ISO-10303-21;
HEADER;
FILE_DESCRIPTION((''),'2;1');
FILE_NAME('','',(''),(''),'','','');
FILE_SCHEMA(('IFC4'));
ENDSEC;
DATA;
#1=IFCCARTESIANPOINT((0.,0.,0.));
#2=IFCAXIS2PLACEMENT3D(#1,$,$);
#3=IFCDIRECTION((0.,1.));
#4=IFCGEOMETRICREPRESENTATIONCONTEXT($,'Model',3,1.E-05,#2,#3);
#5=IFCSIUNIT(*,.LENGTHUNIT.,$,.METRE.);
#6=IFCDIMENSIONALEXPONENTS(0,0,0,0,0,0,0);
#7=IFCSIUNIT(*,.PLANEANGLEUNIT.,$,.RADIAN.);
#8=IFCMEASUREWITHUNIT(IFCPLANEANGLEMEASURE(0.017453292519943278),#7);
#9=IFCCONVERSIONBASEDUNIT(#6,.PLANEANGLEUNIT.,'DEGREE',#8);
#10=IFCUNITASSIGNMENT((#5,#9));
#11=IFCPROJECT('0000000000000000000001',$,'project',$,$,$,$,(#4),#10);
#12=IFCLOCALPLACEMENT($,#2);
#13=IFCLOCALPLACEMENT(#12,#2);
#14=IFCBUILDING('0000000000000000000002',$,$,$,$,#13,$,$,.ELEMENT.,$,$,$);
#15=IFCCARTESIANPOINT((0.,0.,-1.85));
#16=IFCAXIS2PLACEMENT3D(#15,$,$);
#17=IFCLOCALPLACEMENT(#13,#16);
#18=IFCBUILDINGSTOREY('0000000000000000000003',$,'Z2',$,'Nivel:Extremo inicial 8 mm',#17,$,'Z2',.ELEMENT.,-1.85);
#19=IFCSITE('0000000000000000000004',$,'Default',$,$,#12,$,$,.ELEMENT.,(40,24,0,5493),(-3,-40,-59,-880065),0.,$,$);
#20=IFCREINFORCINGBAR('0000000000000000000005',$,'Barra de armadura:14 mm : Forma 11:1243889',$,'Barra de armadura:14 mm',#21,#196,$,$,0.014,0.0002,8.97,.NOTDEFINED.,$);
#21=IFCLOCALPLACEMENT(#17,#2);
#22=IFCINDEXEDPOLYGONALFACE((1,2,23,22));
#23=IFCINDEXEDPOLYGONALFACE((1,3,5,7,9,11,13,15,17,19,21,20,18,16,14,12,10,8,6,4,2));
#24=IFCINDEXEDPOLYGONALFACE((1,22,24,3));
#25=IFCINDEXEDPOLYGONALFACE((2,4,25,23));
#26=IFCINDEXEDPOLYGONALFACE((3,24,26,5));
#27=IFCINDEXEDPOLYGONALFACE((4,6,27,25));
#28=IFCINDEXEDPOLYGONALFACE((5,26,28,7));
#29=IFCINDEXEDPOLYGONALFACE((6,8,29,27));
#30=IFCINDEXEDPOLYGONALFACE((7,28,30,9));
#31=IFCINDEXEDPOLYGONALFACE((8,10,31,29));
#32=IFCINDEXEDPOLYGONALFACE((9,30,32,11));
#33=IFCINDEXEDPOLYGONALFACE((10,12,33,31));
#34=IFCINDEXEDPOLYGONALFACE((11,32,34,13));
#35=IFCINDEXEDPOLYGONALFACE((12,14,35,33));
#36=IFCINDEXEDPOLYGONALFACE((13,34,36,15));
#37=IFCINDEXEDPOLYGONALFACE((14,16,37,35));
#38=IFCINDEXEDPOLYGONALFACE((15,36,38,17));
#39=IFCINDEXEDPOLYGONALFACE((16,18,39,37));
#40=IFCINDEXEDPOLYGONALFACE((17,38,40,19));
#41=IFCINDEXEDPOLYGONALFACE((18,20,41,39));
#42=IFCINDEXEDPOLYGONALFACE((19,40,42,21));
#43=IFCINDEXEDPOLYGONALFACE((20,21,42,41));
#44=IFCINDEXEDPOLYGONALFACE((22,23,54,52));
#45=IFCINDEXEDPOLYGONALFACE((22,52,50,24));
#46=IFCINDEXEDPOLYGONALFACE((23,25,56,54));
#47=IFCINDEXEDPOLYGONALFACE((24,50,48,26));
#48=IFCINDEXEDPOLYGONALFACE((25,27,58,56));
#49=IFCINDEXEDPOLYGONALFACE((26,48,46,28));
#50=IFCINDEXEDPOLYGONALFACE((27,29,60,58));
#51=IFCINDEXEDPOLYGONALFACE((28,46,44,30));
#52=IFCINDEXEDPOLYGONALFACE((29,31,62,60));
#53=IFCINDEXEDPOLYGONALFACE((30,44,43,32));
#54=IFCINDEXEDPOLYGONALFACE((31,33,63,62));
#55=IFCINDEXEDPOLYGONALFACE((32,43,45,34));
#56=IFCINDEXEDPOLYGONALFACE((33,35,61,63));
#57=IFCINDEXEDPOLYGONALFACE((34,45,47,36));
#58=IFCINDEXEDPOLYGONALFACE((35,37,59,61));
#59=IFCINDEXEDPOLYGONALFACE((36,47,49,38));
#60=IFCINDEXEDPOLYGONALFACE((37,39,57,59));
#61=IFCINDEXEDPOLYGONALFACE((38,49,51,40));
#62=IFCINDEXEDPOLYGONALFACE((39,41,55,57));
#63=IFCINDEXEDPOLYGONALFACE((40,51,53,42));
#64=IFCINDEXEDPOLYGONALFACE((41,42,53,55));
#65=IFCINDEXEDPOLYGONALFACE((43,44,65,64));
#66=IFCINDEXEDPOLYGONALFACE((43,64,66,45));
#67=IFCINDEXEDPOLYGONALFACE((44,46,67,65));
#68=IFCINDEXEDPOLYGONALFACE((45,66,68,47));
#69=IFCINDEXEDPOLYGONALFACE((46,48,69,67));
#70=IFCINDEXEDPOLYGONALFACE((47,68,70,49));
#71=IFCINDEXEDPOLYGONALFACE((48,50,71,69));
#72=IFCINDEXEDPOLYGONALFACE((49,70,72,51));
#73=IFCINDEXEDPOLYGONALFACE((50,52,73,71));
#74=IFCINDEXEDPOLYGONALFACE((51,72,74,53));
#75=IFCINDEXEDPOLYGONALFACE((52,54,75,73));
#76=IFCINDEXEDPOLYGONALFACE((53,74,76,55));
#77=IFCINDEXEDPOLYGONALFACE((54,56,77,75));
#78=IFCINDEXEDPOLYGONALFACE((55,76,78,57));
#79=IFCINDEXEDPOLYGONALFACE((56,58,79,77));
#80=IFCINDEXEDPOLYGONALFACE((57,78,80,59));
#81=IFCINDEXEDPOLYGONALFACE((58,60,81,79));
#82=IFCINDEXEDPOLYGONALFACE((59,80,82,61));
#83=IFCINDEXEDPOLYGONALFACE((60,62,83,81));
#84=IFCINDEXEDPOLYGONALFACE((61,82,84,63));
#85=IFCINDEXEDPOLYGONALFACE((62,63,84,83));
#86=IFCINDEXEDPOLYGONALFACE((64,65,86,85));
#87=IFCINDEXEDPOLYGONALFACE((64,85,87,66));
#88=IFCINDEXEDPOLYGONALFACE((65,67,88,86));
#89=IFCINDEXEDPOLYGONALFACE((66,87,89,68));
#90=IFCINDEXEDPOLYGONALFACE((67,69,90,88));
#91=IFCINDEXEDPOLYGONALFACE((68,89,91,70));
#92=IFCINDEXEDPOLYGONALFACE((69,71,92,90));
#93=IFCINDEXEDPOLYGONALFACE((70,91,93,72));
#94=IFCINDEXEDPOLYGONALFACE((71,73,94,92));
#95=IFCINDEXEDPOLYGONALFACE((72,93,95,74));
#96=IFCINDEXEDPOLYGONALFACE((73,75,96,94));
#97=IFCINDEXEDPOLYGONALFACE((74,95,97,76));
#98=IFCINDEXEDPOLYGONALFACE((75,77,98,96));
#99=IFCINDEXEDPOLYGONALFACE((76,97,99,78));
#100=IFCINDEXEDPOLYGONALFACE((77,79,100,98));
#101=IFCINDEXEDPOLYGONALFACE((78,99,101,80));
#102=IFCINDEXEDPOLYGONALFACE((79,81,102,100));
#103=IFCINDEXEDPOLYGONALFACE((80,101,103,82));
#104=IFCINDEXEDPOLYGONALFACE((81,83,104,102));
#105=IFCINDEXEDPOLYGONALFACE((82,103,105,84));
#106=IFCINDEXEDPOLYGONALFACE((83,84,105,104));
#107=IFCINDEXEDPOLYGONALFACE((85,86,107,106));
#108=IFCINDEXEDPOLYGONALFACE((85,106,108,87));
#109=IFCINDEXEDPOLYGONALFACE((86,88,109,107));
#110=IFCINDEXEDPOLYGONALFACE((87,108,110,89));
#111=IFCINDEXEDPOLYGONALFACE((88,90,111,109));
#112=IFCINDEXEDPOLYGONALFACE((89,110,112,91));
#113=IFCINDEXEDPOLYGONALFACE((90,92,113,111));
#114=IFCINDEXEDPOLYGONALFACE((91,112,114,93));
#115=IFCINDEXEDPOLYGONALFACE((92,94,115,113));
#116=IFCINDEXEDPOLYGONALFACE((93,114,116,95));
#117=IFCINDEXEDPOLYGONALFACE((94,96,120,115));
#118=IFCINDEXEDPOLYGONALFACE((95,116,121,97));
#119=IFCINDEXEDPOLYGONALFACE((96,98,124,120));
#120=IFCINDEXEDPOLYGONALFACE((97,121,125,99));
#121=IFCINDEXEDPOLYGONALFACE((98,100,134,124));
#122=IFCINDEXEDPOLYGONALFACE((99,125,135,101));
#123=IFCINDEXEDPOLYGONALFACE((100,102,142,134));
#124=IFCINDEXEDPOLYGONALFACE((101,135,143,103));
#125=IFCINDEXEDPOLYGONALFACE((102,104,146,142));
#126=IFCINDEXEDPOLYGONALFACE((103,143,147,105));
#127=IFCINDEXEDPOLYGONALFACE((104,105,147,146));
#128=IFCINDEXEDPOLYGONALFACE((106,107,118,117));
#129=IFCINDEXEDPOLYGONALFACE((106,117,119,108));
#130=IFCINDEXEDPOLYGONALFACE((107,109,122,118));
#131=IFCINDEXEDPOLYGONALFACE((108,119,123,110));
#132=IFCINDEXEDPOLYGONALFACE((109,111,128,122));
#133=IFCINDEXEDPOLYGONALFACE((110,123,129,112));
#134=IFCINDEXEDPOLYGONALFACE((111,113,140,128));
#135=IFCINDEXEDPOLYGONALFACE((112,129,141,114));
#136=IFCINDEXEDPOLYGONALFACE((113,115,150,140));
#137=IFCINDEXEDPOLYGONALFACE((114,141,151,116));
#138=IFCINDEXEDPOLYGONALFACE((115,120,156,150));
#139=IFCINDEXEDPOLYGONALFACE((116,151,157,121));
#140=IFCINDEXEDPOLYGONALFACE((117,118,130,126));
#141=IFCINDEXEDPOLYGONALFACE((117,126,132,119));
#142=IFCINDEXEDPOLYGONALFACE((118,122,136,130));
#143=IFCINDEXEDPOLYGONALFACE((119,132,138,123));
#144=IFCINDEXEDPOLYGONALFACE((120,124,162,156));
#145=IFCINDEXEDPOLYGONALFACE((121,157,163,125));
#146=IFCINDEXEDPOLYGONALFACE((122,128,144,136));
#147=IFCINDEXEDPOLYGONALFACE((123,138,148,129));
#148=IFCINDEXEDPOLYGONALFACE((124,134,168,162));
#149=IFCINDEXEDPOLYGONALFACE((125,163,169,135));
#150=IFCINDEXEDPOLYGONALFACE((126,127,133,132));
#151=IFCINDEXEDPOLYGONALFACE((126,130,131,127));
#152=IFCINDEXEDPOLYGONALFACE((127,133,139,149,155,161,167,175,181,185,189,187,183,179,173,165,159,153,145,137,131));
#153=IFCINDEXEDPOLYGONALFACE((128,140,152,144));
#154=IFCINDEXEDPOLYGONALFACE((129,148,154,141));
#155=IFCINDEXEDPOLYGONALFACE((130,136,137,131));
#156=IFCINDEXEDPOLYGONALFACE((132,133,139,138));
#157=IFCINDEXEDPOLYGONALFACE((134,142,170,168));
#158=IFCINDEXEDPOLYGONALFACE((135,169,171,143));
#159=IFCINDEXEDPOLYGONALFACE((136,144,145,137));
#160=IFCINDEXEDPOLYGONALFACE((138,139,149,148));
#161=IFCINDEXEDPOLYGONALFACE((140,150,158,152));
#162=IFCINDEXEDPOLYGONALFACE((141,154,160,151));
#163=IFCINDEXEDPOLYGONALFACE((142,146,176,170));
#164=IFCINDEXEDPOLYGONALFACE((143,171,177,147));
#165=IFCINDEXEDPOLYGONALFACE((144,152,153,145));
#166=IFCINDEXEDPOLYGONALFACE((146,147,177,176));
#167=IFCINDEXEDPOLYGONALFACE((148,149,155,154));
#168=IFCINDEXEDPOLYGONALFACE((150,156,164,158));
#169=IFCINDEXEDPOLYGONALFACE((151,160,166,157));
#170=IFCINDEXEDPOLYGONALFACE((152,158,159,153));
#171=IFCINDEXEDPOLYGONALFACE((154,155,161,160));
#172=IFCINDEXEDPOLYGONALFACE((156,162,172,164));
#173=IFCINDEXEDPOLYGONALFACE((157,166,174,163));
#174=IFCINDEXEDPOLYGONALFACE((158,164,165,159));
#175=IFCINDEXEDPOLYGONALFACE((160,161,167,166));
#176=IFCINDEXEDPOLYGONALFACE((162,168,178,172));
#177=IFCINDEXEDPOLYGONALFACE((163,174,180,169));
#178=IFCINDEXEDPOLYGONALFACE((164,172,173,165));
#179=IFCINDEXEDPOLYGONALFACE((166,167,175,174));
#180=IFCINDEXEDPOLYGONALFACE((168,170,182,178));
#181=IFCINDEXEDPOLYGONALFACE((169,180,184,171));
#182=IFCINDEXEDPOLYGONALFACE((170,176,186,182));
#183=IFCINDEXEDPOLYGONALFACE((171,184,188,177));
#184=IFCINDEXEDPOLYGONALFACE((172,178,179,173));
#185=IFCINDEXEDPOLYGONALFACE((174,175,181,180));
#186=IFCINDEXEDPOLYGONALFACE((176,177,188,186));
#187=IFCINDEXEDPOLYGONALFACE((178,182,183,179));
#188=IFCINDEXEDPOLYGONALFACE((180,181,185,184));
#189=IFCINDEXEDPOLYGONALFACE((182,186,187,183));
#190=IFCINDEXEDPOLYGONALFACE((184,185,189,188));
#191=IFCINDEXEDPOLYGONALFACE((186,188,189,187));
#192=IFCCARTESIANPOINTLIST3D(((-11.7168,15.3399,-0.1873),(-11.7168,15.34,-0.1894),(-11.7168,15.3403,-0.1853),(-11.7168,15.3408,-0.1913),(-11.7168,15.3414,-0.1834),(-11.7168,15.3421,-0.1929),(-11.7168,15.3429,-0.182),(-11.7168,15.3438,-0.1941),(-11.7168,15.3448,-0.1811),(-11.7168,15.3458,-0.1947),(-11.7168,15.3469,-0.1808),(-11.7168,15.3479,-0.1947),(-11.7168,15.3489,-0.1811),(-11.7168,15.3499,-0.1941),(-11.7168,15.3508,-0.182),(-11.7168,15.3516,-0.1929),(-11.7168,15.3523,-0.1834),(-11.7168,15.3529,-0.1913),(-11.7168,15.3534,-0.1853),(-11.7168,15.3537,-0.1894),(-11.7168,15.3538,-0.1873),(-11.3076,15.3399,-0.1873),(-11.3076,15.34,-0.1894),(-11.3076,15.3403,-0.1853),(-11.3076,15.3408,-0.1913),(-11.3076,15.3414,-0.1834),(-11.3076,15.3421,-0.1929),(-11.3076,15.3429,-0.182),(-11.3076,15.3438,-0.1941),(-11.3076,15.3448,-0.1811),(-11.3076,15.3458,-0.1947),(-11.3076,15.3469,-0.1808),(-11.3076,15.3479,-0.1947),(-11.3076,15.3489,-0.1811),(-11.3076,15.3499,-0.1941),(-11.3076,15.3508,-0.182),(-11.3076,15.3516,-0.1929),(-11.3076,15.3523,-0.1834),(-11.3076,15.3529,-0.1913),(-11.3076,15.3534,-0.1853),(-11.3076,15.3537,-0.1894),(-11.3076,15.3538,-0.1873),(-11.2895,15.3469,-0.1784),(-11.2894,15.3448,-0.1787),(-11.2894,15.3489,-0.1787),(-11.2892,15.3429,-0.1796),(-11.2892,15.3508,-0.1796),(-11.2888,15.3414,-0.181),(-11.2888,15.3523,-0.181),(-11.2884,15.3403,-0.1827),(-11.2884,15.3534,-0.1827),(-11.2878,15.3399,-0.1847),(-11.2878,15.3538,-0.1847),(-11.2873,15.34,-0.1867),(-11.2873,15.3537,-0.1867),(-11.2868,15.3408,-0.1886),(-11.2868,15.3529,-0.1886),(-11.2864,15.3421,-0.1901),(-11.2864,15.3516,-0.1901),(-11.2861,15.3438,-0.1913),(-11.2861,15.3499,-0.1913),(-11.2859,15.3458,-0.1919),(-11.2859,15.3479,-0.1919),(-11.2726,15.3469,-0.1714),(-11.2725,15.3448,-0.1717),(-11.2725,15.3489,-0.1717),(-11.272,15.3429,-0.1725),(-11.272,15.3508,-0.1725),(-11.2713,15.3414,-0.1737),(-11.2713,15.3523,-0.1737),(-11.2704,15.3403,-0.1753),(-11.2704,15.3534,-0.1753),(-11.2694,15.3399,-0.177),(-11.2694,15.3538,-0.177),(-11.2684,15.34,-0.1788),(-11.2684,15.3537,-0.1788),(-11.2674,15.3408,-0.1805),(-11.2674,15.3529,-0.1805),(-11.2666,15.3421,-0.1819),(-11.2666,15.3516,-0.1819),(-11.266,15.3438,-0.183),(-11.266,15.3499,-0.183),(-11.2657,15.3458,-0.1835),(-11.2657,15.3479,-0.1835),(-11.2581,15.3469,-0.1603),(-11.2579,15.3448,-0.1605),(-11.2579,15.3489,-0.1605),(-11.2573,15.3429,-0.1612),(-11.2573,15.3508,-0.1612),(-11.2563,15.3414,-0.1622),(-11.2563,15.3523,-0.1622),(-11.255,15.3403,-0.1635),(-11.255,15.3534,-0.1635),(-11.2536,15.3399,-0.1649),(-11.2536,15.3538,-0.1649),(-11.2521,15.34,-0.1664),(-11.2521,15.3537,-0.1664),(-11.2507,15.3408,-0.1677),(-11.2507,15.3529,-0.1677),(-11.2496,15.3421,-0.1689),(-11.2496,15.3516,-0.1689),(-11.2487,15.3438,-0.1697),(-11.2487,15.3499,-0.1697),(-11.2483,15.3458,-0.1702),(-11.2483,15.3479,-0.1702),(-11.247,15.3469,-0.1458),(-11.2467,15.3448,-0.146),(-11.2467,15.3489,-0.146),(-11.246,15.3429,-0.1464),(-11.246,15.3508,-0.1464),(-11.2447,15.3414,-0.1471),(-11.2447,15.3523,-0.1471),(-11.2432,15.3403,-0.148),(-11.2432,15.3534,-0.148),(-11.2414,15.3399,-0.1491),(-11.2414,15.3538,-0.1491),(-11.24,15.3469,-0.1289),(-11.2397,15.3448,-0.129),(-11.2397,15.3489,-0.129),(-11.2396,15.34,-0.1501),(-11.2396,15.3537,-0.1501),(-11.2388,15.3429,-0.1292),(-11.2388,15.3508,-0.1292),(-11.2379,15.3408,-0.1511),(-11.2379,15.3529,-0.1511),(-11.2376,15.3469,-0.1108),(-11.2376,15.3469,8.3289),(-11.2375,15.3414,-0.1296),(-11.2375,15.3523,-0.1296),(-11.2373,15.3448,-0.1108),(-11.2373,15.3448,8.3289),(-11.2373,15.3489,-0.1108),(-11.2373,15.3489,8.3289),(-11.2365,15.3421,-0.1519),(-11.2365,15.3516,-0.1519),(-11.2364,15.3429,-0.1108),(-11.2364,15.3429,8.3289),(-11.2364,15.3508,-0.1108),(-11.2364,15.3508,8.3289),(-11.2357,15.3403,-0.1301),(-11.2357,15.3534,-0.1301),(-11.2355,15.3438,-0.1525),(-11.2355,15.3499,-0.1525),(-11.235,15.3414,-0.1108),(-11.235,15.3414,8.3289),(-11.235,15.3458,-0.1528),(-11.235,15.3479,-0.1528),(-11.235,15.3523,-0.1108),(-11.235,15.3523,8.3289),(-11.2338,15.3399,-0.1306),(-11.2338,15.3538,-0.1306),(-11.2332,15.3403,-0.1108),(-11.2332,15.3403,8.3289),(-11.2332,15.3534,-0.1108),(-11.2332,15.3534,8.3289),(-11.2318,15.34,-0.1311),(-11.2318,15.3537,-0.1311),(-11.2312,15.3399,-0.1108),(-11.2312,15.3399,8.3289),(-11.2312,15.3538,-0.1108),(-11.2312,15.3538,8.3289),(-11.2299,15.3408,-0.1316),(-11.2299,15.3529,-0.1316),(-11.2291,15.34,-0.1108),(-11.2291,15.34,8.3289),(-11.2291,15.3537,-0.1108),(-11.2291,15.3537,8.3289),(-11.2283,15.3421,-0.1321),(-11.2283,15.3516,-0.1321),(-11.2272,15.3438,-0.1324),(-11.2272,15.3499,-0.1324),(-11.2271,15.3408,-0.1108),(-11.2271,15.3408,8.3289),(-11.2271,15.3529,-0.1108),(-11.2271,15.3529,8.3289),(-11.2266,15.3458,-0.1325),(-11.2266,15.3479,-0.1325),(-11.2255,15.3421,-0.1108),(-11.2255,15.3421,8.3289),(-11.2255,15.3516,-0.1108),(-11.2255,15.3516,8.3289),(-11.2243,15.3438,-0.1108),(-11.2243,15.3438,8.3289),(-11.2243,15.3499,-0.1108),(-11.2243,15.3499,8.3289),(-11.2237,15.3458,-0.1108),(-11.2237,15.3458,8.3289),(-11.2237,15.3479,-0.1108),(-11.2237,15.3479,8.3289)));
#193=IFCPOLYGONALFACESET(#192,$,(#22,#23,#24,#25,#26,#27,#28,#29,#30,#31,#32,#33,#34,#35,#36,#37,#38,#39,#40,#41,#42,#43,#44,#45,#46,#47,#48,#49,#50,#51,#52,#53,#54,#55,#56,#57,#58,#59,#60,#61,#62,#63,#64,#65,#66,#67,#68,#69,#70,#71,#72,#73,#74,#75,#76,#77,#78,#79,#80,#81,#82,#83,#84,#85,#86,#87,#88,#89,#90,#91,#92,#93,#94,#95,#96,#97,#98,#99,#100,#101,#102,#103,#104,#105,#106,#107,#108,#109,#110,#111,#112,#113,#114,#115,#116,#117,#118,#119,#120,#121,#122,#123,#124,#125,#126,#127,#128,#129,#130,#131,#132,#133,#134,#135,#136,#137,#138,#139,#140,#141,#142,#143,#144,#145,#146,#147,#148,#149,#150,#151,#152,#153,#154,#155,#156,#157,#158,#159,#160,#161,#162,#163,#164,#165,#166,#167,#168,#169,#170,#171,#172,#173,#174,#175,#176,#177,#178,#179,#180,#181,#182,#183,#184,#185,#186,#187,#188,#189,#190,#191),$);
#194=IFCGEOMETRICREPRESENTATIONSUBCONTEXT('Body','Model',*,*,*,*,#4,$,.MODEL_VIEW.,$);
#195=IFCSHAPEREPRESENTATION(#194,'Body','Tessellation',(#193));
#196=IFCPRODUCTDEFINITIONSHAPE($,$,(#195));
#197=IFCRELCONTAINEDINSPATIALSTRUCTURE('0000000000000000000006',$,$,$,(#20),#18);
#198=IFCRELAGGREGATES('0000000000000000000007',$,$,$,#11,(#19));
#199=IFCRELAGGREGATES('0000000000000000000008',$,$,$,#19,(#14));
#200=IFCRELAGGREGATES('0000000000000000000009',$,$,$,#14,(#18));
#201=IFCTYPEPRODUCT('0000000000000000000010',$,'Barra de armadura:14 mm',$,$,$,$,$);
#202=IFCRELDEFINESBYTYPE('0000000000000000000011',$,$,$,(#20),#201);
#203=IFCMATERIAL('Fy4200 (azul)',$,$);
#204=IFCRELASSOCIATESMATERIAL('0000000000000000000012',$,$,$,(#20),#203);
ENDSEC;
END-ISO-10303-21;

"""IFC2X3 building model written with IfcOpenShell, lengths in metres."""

from ifc_helpers import new_model, entity, si_unit, converted_unit, direction, frame, origin, place, context, subcontext, project, spatial, material, type_object, element, save


model = new_model("IFC2X3")

# Units and contexts
model_context = context("Model", 3, precision=1e-05, world=origin(), true_north=direction((0.0, 1.0)))
body_context = subcontext(model_context, "Body", "Model", "MODEL_VIEW")
ifc_project = project(units=[si_unit("LENGTHUNIT", "METRE"), converted_unit("PLANEANGLEUNIT", "DEGREE", entity("IfcPlaneAngleMeasure", 0.017453292519943278), si_unit("PLANEANGLEUNIT", "RADIAN"), dimensions=[0, 0, 0, 0, 0, 0, 0])], contexts=[model_context])

# Site, building, storey
site_placement = place(None, origin())
site = spatial("IfcSite", under=ifc_project, at=site_placement, Name="Default", CompositionType="ELEMENT", RefLatitude=(40, 24, 0, 5493), RefLongitude=(-3, -40, -59, -880065), RefElevation=0.0)
building_placement = place(site_placement, origin())
building = spatial("IfcBuilding", under=site, at=building_placement, CompositionType="ELEMENT")
storey_placement = place(building_placement, frame((0.0, 0.0, -1.85)))
storey = spatial("IfcBuildingStorey", under=building, at=storey_placement, Name="Z2", ObjectType="Nivel:Extremo inicial 8 mm", LongName="Z2", CompositionType="ELEMENT", Elevation=-1.85)

# Reinforcing bar
ifc_material_1 = material(Name="Fy4200 (azul)")
type_product_1 = type_object("IfcTypeProduct", Name="Barra de armadura:14 mm")
reinforcing_bar_1_placement = place(storey_placement, origin())
element("IfcReinforcingBar", 1, at=reinforcing_bar_1_placement, inside=storey, type_object=type_product_1, material=ifc_material_1, Name="Barra de armadura:14 mm : Forma 11:1243889", ObjectType="Barra de armadura:14 mm", BarLength=8.97, BarRole="NOTDEFINED", CrossSectionArea=0.0002, NominalDiameter=0.014, context=body_context, shape_type="AdvancedSweptSolid", body=[
    entity("IfcSweptDiskSolid", entity("IfcCompositeCurve", [entity("IfcCompositeCurveSegment", "CONTINUOUS", True, entity("IfcPolyline", [entity("IfcCartesianPoint", [-11.2306, 15.3469, 8.3289]), entity("IfcCartesianPoint", [-11.2306, 15.3469, -0.1108])])), entity("IfcCompositeCurveSegment", "CONTINUOUS", True, entity("IfcTrimmedCurve", entity("IfcCircle", entity("IfcAxis2Placement3D", entity("IfcCartesianPoint", [-11.3076, 15.3469, -0.1108]), entity("IfcDirection", [0.0, 1.0, 0.0]), entity("IfcDirection", [0.0, 0.0, -1.0])), 0.077), [entity("IfcParameterValue", 270.0)], [entity("IfcParameterValue", 360.0)], True, "PARAMETER")), entity("IfcCompositeCurveSegment", "CONTINUOUS", True, entity("IfcPolyline", [entity("IfcCartesianPoint", [-11.3076, 15.3469, -0.1878]), entity("IfcCartesianPoint", [-11.7168, 15.3469, -0.1878])]))], False), 0.007, None, 0.0, 92.0),
])

save(model, "model.ifc")
